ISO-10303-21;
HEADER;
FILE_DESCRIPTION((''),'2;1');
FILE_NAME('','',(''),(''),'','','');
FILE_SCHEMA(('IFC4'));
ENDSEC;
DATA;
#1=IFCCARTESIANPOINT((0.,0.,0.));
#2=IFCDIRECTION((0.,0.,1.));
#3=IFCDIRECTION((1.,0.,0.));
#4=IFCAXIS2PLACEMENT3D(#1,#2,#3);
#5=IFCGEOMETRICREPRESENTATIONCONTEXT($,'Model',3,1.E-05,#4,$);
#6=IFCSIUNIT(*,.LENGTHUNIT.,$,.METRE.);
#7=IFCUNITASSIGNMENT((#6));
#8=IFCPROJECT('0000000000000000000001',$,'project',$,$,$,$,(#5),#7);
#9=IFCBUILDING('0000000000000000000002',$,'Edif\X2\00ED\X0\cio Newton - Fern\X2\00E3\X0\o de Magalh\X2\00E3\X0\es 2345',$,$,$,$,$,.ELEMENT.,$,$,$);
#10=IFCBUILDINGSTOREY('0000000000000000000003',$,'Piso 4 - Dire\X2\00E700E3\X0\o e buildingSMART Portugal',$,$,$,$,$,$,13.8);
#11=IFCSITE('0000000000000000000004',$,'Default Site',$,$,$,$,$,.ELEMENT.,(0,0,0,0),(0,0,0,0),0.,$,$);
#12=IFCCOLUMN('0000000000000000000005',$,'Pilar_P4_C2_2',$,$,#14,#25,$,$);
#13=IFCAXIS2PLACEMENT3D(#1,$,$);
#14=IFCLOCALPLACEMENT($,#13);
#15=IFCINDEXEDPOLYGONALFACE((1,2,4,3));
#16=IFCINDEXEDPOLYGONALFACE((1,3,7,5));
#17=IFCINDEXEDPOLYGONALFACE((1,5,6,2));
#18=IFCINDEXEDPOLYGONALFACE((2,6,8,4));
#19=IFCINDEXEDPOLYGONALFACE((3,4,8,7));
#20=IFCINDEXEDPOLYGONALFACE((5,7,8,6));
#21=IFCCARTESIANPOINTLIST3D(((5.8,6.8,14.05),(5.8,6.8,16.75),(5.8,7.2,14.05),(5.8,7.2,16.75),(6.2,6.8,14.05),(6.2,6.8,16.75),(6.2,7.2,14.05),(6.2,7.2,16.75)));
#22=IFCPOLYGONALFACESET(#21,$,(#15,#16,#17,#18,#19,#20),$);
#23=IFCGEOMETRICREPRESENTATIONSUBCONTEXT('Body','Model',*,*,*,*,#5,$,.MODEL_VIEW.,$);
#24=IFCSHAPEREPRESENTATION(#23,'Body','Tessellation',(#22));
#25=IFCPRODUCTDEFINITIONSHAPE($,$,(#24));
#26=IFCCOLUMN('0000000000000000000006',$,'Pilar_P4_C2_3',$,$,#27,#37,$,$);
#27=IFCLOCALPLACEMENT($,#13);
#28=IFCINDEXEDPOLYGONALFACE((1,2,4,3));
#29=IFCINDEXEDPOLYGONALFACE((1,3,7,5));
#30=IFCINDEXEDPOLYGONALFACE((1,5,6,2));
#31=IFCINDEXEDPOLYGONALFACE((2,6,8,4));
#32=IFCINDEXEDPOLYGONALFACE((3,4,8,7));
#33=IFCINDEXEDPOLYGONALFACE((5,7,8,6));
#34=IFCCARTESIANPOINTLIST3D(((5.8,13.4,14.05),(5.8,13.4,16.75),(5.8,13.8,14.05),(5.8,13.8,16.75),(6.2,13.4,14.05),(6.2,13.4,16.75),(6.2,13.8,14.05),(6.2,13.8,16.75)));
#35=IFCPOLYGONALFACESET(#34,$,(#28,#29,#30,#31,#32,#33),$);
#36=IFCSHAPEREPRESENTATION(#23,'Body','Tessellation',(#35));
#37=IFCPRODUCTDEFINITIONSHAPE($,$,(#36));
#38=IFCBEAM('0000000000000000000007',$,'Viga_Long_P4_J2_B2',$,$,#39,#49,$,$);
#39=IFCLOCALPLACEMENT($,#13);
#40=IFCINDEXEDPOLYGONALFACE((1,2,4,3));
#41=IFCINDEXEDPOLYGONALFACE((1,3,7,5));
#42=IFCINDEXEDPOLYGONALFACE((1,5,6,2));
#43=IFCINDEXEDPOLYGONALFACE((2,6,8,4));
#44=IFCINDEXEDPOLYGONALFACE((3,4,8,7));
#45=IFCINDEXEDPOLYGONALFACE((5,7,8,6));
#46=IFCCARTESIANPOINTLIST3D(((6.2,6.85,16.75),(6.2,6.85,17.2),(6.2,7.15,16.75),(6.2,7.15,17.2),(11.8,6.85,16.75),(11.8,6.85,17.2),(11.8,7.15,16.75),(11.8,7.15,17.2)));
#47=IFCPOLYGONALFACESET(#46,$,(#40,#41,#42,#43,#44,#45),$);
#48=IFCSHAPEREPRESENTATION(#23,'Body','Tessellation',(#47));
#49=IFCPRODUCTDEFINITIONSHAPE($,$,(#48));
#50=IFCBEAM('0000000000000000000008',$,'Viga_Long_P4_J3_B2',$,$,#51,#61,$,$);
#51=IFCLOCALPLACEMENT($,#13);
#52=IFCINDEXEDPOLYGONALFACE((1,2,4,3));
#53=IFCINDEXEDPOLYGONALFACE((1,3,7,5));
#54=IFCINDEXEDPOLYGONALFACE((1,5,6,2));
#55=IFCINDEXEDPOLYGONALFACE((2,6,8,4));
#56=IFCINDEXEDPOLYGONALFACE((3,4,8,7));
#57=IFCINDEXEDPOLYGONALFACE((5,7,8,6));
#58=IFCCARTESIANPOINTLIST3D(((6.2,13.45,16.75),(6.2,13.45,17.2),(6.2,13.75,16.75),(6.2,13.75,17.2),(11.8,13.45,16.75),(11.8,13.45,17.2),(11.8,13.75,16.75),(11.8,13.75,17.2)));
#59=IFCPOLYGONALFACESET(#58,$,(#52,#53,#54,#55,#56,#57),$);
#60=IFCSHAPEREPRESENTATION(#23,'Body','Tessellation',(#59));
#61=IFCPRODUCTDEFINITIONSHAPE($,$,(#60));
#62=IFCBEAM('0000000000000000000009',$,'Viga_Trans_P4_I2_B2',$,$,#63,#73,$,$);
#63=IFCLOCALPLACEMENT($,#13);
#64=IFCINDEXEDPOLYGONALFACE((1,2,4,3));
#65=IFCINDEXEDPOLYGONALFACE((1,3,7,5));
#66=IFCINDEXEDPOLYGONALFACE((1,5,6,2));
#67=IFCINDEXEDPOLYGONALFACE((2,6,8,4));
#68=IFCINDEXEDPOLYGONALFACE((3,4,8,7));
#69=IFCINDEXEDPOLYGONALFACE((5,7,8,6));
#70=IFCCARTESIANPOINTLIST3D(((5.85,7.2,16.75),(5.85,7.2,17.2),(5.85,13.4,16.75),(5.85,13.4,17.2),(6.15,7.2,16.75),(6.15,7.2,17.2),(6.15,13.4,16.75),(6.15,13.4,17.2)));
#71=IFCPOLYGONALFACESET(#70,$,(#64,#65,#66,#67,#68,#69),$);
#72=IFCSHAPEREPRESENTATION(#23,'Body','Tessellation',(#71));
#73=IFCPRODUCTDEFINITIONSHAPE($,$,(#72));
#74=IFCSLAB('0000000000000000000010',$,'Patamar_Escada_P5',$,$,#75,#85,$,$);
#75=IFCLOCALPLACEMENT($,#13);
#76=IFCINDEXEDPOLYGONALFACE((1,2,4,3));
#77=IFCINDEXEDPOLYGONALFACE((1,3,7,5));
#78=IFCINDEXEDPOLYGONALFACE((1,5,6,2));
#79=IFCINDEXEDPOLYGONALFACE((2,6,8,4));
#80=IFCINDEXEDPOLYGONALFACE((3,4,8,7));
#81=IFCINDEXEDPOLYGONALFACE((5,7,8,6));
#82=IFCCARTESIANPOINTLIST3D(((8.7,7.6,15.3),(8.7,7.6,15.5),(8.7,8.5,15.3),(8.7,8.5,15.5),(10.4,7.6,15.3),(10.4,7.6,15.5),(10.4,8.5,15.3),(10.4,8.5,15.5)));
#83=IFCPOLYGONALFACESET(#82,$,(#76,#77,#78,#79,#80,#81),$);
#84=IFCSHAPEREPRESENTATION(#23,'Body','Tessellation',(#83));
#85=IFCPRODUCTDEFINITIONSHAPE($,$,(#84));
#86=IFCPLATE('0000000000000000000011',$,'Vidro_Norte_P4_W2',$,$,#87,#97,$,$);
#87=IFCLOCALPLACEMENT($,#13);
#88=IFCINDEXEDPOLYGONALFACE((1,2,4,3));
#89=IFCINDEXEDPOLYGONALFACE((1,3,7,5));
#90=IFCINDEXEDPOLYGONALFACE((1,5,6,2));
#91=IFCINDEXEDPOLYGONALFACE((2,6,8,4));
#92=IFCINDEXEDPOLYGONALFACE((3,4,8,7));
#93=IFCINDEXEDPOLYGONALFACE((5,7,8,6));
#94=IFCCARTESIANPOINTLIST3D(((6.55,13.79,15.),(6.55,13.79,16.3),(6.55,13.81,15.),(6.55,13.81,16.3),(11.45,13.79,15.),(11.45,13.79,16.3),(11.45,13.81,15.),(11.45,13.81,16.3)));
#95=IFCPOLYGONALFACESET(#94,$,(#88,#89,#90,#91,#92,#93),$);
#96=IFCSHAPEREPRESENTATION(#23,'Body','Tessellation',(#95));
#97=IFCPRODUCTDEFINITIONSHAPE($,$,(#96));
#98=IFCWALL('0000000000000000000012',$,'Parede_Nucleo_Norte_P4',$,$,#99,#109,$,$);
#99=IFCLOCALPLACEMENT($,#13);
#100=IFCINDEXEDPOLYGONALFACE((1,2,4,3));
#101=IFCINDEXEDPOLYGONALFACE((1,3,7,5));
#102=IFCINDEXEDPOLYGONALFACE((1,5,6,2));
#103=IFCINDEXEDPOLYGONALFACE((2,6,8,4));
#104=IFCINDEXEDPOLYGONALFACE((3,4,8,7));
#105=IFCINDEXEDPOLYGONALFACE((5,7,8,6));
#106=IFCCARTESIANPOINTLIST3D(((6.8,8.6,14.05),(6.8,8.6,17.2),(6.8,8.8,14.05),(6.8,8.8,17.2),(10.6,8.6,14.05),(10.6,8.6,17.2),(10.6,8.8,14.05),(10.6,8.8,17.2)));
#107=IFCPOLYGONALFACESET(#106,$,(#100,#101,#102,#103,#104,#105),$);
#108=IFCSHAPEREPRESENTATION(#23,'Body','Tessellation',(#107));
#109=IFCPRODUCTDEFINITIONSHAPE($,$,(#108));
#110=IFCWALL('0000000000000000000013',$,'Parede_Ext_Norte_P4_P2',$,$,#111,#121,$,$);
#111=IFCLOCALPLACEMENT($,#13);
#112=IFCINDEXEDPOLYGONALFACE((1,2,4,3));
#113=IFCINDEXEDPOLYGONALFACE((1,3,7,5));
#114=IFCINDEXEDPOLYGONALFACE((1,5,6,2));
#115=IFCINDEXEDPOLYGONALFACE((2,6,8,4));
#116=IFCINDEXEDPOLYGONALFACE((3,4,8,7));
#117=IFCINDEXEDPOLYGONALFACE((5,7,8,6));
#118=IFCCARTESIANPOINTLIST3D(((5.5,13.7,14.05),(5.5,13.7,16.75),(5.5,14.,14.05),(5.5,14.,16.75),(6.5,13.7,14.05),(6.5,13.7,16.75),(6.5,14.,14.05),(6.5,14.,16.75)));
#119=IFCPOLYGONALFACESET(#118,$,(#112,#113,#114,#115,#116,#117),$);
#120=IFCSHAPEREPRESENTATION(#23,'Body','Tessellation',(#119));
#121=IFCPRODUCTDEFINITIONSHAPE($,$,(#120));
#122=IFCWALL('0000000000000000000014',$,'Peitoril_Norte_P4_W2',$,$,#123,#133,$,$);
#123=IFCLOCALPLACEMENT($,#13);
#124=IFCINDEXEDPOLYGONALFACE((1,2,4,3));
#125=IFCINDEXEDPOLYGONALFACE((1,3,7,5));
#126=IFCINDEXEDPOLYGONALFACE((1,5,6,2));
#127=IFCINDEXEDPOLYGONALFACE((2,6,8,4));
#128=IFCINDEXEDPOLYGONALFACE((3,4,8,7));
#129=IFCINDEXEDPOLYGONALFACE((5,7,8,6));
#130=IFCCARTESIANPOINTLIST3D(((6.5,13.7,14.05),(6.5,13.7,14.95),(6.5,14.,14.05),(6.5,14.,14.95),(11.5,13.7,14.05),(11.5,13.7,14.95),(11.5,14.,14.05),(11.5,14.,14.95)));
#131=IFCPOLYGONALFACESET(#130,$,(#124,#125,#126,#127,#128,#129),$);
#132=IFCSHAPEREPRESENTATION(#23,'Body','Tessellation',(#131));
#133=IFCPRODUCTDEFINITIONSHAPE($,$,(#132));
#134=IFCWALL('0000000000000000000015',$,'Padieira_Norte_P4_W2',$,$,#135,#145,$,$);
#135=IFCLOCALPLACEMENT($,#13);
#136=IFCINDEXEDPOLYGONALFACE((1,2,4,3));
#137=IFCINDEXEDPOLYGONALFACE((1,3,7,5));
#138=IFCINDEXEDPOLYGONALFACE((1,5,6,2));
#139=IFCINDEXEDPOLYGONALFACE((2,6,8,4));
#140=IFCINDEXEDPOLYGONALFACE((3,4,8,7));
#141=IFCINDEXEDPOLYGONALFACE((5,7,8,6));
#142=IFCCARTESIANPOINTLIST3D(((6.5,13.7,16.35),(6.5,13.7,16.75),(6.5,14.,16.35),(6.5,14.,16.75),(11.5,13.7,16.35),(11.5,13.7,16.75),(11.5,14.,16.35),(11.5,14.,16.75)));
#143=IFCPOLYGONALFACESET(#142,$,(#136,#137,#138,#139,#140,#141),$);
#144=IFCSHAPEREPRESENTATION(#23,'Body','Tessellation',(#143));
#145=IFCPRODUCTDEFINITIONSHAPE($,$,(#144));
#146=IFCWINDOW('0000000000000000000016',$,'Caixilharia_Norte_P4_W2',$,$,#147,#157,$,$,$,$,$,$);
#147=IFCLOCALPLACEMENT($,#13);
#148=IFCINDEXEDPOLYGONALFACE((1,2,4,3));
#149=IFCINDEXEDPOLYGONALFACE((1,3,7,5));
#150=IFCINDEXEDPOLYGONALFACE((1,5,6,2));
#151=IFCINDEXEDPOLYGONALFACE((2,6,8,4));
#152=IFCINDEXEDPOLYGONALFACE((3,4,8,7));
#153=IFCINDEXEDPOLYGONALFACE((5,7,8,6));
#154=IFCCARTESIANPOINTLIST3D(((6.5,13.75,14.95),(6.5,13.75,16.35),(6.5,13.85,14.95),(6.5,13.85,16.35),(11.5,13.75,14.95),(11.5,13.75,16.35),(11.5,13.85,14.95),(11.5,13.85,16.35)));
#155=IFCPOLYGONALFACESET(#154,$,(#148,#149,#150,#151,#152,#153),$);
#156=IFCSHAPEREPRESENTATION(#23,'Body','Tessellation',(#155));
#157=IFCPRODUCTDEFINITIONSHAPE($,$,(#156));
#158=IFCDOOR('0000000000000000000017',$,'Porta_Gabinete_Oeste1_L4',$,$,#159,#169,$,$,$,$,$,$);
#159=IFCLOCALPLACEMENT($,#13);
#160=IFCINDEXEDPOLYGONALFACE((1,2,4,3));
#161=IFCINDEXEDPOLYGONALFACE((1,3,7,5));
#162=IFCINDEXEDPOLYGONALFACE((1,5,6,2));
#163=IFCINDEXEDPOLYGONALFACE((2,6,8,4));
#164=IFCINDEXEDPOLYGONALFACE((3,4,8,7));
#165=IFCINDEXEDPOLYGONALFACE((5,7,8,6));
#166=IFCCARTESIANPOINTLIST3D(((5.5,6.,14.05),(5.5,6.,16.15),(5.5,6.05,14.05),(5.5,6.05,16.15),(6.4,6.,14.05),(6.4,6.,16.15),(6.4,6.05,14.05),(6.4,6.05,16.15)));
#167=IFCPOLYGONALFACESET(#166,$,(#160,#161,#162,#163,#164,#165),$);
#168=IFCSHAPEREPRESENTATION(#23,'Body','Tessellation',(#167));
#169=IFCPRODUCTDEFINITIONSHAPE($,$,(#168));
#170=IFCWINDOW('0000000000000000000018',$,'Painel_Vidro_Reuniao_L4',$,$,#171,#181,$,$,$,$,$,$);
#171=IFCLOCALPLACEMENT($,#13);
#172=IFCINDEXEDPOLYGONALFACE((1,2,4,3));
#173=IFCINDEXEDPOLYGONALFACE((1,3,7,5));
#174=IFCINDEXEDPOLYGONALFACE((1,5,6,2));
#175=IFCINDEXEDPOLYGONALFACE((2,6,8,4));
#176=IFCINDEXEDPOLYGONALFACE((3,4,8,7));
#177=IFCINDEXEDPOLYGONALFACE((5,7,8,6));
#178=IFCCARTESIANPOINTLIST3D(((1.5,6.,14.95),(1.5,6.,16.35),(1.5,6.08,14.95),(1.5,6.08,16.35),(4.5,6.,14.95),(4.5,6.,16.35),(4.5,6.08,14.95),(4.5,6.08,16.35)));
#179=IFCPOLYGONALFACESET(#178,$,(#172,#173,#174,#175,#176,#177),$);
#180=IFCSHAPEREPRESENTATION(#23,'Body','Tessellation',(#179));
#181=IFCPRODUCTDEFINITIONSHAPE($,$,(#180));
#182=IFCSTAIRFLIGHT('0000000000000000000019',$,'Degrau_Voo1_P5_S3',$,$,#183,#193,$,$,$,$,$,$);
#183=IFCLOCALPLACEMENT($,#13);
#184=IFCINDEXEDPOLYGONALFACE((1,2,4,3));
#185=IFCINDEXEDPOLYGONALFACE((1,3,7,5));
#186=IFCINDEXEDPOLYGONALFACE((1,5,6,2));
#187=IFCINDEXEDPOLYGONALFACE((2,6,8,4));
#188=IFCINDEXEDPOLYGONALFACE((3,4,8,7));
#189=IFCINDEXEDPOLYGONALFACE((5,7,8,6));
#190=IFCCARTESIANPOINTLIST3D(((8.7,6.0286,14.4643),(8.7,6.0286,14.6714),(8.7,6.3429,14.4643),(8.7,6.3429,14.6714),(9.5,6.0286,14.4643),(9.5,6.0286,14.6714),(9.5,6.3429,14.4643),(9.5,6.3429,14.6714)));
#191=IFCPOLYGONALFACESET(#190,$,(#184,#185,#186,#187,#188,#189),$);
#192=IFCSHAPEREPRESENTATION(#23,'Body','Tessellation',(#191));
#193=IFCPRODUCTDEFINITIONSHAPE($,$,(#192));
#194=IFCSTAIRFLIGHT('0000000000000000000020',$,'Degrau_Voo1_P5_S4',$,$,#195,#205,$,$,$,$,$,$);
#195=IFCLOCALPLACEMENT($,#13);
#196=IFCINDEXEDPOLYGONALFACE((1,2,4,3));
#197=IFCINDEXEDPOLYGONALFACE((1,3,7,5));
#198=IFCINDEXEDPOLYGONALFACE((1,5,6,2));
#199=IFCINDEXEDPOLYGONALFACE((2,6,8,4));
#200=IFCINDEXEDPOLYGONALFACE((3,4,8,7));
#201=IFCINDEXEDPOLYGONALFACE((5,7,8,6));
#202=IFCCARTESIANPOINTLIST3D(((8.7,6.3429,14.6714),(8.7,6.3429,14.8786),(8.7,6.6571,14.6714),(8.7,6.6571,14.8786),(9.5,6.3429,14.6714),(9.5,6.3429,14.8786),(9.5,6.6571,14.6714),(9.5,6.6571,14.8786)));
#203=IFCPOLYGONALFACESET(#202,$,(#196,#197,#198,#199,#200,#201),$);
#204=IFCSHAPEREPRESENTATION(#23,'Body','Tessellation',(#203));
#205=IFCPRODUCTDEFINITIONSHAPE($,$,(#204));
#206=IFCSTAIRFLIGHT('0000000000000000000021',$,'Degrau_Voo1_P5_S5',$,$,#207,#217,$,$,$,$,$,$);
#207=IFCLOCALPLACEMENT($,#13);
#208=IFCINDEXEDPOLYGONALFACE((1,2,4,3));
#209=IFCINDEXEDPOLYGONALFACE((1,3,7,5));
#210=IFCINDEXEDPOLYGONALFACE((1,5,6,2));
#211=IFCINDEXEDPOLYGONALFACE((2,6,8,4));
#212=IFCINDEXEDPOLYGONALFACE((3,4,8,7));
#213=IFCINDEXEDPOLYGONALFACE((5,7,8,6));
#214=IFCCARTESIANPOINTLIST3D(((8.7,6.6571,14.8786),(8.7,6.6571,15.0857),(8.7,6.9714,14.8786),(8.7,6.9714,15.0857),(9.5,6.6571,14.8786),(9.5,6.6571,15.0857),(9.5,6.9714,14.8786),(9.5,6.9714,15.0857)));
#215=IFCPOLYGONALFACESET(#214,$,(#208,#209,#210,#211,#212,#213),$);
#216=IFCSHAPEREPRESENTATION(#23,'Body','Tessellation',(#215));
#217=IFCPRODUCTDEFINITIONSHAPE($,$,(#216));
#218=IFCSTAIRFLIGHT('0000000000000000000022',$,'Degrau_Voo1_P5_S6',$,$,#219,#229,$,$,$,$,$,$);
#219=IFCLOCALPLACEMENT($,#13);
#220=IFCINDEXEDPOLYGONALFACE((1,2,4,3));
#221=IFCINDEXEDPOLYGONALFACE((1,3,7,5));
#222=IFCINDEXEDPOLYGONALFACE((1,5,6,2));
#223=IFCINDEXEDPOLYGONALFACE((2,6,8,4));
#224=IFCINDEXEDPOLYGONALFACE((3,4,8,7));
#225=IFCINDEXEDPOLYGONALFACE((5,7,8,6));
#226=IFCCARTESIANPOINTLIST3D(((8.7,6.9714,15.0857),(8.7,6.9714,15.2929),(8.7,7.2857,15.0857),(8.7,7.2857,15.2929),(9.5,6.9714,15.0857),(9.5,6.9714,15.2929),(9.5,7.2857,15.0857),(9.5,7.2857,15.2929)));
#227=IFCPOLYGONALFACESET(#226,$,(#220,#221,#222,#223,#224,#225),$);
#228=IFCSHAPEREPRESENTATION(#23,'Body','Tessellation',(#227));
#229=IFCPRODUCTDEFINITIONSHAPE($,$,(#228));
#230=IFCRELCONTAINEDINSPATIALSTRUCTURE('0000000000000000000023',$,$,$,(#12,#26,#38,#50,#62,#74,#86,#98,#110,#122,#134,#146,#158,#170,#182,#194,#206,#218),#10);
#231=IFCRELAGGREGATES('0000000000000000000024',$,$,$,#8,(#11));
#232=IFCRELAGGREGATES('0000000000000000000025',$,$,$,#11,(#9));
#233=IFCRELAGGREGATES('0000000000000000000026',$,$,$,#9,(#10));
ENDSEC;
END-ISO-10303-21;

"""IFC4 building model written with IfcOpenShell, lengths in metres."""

from ifc_helpers import new_model, si_unit, frame, frame_2d, origin_with_axes, place, context, subcontext, project, spatial, rectangle, extrude, element, save


model = new_model("IFC4")

# Units and contexts
model_context = context("Model", 3, precision=1e-05, world=origin_with_axes())
body_context = subcontext(model_context, "Body", "Model", "MODEL_VIEW")
ifc_project = project(units=[si_unit("LENGTHUNIT", "METRE")], contexts=[model_context])

# Site, building, storey
site = spatial("IfcSite", under=ifc_project, Name="Default Site", CompositionType="ELEMENT", RefLatitude=(0, 0, 0, 0), RefLongitude=(0, 0, 0, 0), RefElevation=0.0)
building = spatial("IfcBuilding", under=site, Name="Edifício Newton - Fernão de Magalhães 2345", CompositionType="ELEMENT")
storey = spatial("IfcBuildingStorey", under=building, Name="Piso 4 - Direção e buildingSMART Portugal", Elevation=13.8)

# Columns
for number, where, z_axis, x_axis, name in (
    (1, (5.8, 6.8, 14.05), (0.0, 0.0, 1.0), (1.0, 0.0, 0.0), "Pilar_P4_C2_2"),
    (2, (5.8, 13.4, 14.05), (0.0, 0.0, 1.0), (1.0, 0.0, 0.0), "Pilar_P4_C2_3"),
):
    element("IfcColumn", number, at=place(None, frame(where, z_axis=z_axis, x_axis=x_axis)), inside=storey, Name=name, context=body_context, shape_type="SweptSolid", body=[
        extrude(rectangle(XDim=0.4, YDim=0.4, at=frame_2d((0.2, 0.2))), origin_with_axes(), (0.0, 0.0, 1.0), 2.7),
    ])

# Beams
for number, where, z_axis, x_axis, name in (
    (3, (6.2, 6.85, 16.75), (0.0, 0.0, 1.0), (1.0, 0.0, 0.0), "Viga_Long_P4_J2_B2"),
    (4, (6.2, 13.45, 16.75), (0.0, 0.0, 1.0), (1.0, 0.0, 0.0), "Viga_Long_P4_J3_B2"),
):
    element("IfcBeam", number, at=place(None, frame(where, z_axis=z_axis, x_axis=x_axis)), inside=storey, Name=name, context=body_context, shape_type="SweptSolid", body=[
        extrude(rectangle(XDim=5.6, YDim=0.3, at=frame_2d((2.8, 0.15))), origin_with_axes(), (0.0, 0.0, 1.0), 0.45),
    ])
beam_placement = place(None, frame((5.85, 7.2, 16.75), z_axis=(0.0, 0.0, 1.0), x_axis=(1.0, 0.0, 0.0)))
element("IfcBeam", 5, at=beam_placement, inside=storey, Name="Viga_Trans_P4_I2_B2", context=body_context, shape_type="SweptSolid", body=[
    extrude(rectangle(XDim=0.3, YDim=6.2, at=frame_2d((0.15, 3.1))), origin_with_axes(), (0.0, 0.0, 1.0), 0.45),
])

# Slab
slab_placement = place(None, frame((8.7, 7.6, 15.3), z_axis=(0.0, 0.0, 1.0), x_axis=(1.0, 0.0, 0.0)))
element("IfcSlab", 6, at=slab_placement, inside=storey, Name="Patamar_Escada_P5", context=body_context, shape_type="SweptSolid", body=[
    extrude(rectangle(XDim=1.7, YDim=0.9, at=frame_2d((0.85, 0.45))), origin_with_axes(), (0.0, 0.0, 1.0), 0.2),
])

# Plate
plate_placement = place(None, frame((6.55, 13.79, 15.0), z_axis=(0.0, 0.0, 1.0), x_axis=(1.0, 0.0, 0.0)))
element("IfcPlate", 7, at=plate_placement, inside=storey, Name="Vidro_Norte_P4_W2", context=body_context, shape_type="SweptSolid", body=[
    extrude(rectangle(XDim=4.9, YDim=0.02, at=frame_2d((2.45, 0.01))), origin_with_axes(), (0.0, 0.0, 1.0), 1.3),
])

# Walls
wall_1_placement = place(None, frame((6.8, 8.6, 14.05), z_axis=(0.0, 0.0, 1.0), x_axis=(1.0, 0.0, 0.0)))
element("IfcWall", 8, at=wall_1_placement, inside=storey, Name="Parede_Nucleo_Norte_P4", context=body_context, shape_type="SweptSolid", body=[
    extrude(rectangle(XDim=3.8, YDim=0.2, at=frame_2d((1.9, 0.1))), origin_with_axes(), (0.0, 0.0, 1.0), 3.15),
])
wall_2_placement = place(None, frame((5.5, 13.7, 14.05), z_axis=(0.0, 0.0, 1.0), x_axis=(1.0, 0.0, 0.0)))
element("IfcWall", 9, at=wall_2_placement, inside=storey, Name="Parede_Ext_Norte_P4_P2", context=body_context, shape_type="SweptSolid", body=[
    extrude(rectangle(XDim=1.0, YDim=0.3, at=frame_2d((0.5, 0.15))), origin_with_axes(), (0.0, 0.0, 1.0), 2.7),
])
wall_3_placement = place(None, frame((6.5, 13.7, 14.05), z_axis=(0.0, 0.0, 1.0), x_axis=(1.0, 0.0, 0.0)))
element("IfcWall", 10, at=wall_3_placement, inside=storey, Name="Peitoril_Norte_P4_W2", context=body_context, shape_type="SweptSolid", body=[
    extrude(rectangle(XDim=5.0, YDim=0.3, at=frame_2d((2.5, 0.15))), origin_with_axes(), (0.0, 0.0, 1.0), 0.9),
])
wall_4_placement = place(None, frame((6.5, 13.7, 16.35), z_axis=(0.0, 0.0, 1.0), x_axis=(1.0, 0.0, 0.0)))
element("IfcWall", 11, at=wall_4_placement, inside=storey, Name="Padieira_Norte_P4_W2", context=body_context, shape_type="SweptSolid", body=[
    extrude(rectangle(XDim=5.0, YDim=0.3, at=frame_2d((2.5, 0.15))), origin_with_axes(), (0.0, 0.0, 1.0), 0.4),
])

# Window
window_1_placement = place(None, frame((6.5, 13.75, 14.95), z_axis=(0.0, 0.0, 1.0), x_axis=(1.0, 0.0, 0.0)))
element("IfcWindow", 12, at=window_1_placement, inside=storey, Name="Caixilharia_Norte_P4_W2", context=body_context, shape_type="SweptSolid", body=[
    extrude(rectangle(XDim=5.0, YDim=0.1, at=frame_2d((2.5, 0.05))), origin_with_axes(), (0.0, 0.0, 1.0), 1.4),
])

# Door
door_placement = place(None, frame((5.5, 6.0, 14.05), z_axis=(0.0, 0.0, 1.0), x_axis=(1.0, 0.0, 0.0)))
element("IfcDoor", 13, at=door_placement, inside=storey, Name="Porta_Gabinete_Oeste1_L4", context=body_context, shape_type="SweptSolid", body=[
    extrude(rectangle(XDim=0.9, YDim=0.05, at=frame_2d((0.45, 0.025))), origin_with_axes(), (0.0, 0.0, 1.0), 2.1),
])

# Window
window_2_placement = place(None, frame((1.5, 6.0, 14.95), z_axis=(0.0, 0.0, 1.0), x_axis=(1.0, 0.0, 0.0)))
element("IfcWindow", 14, at=window_2_placement, inside=storey, Name="Painel_Vidro_Reuniao_L4", context=body_context, shape_type="SweptSolid", body=[
    extrude(rectangle(XDim=3.0, YDim=0.08, at=frame_2d((1.5, 0.04))), origin_with_axes(), (0.0, 0.0, 1.0), 1.4),
])

# Stair flights
for number, where, z_axis, x_axis, name in (
    (15, (8.7, 6.0286, 14.4643), (0.0, 0.0, 1.0), (1.0, 0.0, 0.0), "Degrau_Voo1_P5_S3"),
    (16, (8.7, 6.3429, 14.6714), (0.0, 0.0, 1.0), (1.0, 0.0, 0.0), "Degrau_Voo1_P5_S4"),
    (17, (8.7, 6.6571, 14.8786), (0.0, 0.0, 1.0), (1.0, 0.0, 0.0), "Degrau_Voo1_P5_S5"),
    (18, (8.7, 6.9714, 15.0857), (0.0, 0.0, 1.0), (1.0, 0.0, 0.0), "Degrau_Voo1_P5_S6"),
):
    element("IfcStairFlight", number, at=place(None, frame(where, z_axis=z_axis, x_axis=x_axis)), inside=storey, Name=name, context=body_context, shape_type="SweptSolid", body=[
        extrude(rectangle(XDim=0.8, YDim=0.3143, at=frame_2d((0.4, 0.1571))), origin_with_axes(), (0.0, 0.0, 1.0), 0.2071),
    ])

save(model, "model.ifc")
